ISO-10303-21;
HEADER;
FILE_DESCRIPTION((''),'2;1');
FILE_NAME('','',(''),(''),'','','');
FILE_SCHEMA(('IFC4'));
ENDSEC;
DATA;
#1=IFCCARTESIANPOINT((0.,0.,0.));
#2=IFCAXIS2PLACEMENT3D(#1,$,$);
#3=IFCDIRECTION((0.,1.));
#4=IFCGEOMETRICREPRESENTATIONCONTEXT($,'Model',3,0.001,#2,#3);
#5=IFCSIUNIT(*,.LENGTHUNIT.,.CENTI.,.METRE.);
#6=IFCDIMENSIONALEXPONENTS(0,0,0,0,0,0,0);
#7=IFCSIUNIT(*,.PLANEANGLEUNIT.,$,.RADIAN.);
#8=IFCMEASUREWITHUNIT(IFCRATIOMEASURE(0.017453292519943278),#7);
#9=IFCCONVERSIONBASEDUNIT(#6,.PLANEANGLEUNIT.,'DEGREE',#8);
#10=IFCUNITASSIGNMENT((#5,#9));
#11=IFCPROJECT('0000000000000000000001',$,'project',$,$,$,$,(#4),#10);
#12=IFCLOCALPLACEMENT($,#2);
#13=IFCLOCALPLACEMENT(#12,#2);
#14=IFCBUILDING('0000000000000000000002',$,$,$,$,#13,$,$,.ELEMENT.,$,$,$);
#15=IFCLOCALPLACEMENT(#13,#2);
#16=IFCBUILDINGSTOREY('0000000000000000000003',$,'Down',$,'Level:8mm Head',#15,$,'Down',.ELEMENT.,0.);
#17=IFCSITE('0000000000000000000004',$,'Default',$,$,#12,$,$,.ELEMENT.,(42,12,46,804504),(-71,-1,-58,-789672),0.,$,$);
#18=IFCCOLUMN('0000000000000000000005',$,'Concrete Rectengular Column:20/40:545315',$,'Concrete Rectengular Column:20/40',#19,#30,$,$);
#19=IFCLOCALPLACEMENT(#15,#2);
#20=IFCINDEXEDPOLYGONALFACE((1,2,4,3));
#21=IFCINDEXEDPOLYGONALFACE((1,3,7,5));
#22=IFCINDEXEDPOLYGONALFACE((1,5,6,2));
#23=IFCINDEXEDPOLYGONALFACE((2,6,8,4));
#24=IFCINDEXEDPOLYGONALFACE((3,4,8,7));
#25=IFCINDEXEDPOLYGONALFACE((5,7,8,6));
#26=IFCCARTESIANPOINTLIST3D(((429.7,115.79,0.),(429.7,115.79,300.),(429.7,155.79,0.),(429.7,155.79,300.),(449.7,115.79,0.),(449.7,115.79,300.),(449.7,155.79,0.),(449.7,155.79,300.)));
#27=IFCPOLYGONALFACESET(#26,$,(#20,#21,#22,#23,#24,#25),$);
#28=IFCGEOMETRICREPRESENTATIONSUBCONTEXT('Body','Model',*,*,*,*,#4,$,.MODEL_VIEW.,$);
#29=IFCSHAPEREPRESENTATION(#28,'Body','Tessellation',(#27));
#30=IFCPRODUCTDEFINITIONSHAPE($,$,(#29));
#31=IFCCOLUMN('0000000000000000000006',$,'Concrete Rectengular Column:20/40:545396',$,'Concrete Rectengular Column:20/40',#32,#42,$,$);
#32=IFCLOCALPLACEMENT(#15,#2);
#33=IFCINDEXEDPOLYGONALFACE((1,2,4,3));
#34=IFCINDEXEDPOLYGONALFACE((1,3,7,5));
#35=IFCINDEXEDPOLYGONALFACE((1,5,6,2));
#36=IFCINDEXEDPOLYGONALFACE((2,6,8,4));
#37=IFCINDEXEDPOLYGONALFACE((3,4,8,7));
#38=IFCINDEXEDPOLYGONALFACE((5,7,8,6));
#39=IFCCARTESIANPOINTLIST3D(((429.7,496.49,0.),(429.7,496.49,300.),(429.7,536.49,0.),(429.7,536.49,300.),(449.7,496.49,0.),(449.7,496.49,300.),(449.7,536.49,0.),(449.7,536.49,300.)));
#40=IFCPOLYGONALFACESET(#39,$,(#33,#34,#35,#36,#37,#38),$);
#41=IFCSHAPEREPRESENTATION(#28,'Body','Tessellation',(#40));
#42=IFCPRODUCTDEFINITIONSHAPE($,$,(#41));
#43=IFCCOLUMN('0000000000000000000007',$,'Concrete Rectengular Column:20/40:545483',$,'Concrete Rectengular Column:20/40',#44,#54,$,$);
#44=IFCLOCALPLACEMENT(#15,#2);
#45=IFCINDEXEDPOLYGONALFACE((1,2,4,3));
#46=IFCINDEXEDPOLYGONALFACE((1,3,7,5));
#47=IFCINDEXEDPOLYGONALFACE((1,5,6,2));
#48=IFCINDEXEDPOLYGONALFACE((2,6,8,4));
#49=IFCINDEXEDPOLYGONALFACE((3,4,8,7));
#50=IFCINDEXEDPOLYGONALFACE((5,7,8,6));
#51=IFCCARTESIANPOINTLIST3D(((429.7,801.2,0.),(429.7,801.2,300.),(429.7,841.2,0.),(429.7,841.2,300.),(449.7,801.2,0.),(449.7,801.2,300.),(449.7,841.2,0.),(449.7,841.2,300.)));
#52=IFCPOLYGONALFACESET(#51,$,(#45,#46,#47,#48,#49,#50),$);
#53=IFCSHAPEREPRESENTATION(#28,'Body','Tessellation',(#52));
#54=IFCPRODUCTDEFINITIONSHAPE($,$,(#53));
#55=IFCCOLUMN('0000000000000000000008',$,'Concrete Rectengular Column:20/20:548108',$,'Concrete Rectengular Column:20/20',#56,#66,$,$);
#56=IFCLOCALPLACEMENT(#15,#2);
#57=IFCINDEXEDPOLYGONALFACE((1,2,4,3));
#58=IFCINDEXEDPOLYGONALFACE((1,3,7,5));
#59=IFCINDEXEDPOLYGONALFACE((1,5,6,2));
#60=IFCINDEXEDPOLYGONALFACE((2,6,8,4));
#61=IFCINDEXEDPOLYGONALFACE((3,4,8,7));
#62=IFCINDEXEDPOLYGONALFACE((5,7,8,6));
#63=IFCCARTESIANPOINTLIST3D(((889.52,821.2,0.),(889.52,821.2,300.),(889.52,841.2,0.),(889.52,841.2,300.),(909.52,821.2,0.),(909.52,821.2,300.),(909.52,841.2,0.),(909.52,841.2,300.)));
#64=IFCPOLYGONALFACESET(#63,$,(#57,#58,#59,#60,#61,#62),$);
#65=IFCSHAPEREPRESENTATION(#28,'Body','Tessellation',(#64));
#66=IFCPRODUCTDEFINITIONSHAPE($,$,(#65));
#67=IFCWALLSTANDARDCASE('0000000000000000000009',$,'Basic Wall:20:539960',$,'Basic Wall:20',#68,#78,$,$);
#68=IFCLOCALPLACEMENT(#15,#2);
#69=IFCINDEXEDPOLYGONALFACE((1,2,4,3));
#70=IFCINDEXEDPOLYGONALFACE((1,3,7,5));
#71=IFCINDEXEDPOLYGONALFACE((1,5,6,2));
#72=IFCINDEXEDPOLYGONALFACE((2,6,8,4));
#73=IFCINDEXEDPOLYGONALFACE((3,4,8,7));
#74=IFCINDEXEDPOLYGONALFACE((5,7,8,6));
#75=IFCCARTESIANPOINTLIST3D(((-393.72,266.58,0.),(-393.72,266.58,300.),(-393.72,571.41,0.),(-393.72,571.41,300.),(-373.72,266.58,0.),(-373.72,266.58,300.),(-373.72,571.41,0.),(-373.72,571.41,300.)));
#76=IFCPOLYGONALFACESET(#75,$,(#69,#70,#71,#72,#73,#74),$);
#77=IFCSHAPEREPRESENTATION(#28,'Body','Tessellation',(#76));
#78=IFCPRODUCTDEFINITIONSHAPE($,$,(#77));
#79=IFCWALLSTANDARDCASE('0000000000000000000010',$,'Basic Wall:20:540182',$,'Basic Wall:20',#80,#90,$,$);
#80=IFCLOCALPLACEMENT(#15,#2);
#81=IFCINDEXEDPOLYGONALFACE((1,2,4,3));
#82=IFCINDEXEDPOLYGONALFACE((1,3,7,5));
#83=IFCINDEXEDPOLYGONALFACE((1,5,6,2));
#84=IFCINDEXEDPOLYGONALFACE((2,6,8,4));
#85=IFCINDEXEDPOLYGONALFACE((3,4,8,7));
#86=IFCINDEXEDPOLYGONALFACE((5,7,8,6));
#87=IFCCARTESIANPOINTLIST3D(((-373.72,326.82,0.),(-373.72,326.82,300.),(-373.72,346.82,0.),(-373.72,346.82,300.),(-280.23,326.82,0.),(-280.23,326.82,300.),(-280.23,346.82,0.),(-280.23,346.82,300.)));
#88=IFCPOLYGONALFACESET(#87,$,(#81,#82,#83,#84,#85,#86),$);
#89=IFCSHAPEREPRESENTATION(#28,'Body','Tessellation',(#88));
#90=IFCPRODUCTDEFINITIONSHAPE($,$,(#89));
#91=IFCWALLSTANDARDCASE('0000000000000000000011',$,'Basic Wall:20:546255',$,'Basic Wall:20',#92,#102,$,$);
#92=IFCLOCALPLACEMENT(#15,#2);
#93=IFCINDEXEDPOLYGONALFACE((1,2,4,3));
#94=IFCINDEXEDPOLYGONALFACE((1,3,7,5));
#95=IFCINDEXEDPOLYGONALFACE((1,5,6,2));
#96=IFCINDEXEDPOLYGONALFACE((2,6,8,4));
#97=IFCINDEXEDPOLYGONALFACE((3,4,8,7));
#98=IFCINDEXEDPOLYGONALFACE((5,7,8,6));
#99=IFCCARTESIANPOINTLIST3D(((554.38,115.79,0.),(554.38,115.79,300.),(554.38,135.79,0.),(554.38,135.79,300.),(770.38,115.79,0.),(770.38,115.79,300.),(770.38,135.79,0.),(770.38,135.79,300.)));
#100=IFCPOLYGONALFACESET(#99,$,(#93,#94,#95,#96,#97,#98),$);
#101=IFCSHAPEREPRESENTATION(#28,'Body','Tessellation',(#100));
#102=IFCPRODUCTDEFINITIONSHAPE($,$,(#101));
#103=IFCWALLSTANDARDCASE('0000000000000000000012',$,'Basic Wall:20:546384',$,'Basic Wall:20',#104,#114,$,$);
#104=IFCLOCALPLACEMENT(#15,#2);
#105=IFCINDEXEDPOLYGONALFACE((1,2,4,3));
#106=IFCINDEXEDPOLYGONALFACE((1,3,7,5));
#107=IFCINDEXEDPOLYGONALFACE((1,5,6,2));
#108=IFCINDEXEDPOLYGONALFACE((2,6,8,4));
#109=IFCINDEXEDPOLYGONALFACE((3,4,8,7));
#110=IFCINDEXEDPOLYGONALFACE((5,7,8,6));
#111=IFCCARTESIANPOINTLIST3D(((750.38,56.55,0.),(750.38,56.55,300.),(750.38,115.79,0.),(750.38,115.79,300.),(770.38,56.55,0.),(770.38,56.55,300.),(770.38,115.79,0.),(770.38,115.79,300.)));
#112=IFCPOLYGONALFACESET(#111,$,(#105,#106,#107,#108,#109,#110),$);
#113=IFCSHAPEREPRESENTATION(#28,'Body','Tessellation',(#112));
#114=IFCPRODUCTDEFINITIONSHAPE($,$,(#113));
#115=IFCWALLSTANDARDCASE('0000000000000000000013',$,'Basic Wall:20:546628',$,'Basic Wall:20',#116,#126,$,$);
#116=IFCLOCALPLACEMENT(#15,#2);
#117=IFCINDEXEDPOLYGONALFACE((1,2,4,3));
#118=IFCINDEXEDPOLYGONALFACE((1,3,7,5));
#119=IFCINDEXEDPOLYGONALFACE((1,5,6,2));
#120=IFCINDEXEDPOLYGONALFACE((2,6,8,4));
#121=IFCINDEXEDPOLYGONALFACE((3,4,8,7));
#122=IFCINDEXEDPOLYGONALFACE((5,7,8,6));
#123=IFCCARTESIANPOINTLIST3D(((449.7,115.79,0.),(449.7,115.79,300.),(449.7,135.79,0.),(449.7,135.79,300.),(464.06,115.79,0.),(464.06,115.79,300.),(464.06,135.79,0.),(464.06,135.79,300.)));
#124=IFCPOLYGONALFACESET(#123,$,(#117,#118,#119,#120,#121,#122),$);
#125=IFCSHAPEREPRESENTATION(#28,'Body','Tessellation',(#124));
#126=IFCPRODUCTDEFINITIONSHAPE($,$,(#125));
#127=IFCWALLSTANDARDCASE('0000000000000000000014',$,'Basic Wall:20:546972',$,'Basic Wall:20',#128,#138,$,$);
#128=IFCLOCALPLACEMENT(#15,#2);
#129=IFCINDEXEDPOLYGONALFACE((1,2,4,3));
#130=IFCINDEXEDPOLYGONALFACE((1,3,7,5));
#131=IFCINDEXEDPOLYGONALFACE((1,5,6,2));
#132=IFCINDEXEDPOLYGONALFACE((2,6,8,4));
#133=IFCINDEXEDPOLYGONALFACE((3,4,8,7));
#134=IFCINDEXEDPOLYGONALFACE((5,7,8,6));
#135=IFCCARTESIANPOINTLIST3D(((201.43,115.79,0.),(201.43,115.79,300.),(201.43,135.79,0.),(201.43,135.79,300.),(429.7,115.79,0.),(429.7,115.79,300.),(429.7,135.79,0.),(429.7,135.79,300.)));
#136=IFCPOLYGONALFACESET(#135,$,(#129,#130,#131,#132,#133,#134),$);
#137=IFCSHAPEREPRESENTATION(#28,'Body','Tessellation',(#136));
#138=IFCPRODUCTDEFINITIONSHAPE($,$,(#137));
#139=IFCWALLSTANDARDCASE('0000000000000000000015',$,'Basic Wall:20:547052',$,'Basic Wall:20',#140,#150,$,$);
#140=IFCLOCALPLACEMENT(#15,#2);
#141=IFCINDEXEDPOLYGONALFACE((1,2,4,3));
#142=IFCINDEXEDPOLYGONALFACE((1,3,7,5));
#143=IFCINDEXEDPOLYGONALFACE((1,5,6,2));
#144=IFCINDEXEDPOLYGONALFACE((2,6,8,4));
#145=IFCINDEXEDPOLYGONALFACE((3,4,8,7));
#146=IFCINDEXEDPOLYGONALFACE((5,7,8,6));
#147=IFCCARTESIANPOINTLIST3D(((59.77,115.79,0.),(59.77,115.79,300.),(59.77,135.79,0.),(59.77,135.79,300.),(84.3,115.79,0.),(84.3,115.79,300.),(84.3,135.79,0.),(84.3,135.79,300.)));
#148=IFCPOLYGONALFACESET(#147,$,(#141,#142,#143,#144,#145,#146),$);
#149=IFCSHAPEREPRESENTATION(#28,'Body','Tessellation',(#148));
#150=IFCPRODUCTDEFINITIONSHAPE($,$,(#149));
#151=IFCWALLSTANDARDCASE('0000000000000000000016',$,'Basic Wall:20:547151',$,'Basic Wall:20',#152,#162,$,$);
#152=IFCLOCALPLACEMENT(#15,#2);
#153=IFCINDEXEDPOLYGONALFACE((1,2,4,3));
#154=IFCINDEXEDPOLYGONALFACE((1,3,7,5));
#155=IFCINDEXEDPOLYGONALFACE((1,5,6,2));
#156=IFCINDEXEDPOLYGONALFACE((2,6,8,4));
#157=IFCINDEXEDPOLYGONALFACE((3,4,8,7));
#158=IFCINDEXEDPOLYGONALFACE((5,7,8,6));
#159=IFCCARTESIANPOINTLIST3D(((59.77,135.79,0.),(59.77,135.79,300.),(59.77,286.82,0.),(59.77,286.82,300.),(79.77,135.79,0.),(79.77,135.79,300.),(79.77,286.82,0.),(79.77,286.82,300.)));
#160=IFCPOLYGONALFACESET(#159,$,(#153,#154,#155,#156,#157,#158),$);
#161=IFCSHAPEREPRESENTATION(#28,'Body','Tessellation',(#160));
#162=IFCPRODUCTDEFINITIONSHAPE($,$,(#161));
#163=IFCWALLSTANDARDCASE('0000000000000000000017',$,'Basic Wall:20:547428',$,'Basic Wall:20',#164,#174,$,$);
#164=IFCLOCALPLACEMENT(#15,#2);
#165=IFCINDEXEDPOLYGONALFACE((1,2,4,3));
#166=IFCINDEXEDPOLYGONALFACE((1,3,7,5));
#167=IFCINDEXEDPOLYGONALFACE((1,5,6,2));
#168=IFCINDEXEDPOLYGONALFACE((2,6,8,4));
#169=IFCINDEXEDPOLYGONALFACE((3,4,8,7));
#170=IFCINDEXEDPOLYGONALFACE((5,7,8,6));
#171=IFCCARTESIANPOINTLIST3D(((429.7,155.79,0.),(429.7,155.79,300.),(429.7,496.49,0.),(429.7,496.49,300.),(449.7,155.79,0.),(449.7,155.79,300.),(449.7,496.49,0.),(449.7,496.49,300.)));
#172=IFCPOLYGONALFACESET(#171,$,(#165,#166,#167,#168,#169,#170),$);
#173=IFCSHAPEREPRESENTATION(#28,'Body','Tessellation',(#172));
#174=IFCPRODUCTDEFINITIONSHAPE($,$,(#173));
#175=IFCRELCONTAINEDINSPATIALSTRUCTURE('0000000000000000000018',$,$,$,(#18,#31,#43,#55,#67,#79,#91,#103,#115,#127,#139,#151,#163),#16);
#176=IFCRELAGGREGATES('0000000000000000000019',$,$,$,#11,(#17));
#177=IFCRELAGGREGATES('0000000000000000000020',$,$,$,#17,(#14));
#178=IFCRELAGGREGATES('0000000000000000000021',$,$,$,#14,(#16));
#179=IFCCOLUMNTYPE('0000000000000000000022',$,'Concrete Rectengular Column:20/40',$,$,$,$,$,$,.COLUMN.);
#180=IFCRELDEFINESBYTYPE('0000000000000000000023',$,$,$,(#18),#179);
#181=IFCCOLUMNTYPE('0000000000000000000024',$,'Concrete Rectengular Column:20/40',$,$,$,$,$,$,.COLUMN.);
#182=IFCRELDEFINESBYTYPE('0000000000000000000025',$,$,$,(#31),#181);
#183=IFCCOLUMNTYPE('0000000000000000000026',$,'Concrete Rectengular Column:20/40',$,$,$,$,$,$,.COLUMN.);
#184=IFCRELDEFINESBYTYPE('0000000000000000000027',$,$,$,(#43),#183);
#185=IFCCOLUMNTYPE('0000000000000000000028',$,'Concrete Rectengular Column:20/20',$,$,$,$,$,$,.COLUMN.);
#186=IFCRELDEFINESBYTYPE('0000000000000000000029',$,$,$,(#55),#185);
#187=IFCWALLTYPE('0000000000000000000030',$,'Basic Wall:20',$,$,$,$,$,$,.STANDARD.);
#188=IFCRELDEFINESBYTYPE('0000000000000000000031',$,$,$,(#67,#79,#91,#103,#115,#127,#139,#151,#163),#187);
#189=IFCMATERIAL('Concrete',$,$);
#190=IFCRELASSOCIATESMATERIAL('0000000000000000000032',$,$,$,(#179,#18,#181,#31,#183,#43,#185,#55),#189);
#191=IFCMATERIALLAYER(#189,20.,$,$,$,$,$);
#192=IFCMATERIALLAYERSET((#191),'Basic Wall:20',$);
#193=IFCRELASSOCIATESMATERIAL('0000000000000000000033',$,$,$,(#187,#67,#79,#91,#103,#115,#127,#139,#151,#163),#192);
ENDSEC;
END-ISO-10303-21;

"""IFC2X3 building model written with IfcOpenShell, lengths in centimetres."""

from ifc_helpers import new_model, entity, si_unit, converted_unit, direction, frame, frame_2d, origin, origin_2d_with_axis, place, context, subcontext, project, spatial, polyline, rectangle, extrude, clip, bounded_halfspace, source, transform, mapped, material, layer, layer_set, layer_usage, type_object, type_shapes, element, save


model = new_model("IFC2X3")

# Units and contexts
model_context = context("Model", 3, precision=0.001, world=origin(), true_north=direction((0.0, 1.0)))
body_context = subcontext(model_context, "Body", "Model", "MODEL_VIEW")
ifc_project = project(units=[si_unit("LENGTHUNIT", "METRE", prefix="CENTI"), converted_unit("PLANEANGLEUNIT", "DEGREE", entity("IfcRatioMeasure", 0.017453292519943278), si_unit("PLANEANGLEUNIT", "RADIAN"), dimensions=[0, 0, 0, 0, 0, 0, 0])], contexts=[model_context])

# Site, building, storey
site_placement = place(None, origin())
site = spatial("IfcSite", under=ifc_project, at=site_placement, Name="Default", CompositionType="ELEMENT", RefLatitude=(42, 12, 46, 804504), RefLongitude=(-71, -1, -58, -789672), RefElevation=0.0)
building_placement = place(site_placement, origin())
building = spatial("IfcBuilding", under=site, at=building_placement, CompositionType="ELEMENT")
storey_placement = place(building_placement, origin())
storey = spatial("IfcBuildingStorey", under=building, at=storey_placement, Name="Down", ObjectType="Level:8mm Head", LongName="Down", CompositionType="ELEMENT", Elevation=0.0)

# Columns
ifc_material = material(Name="Concrete")
column_type_1 = type_object("IfcColumnType", Name="Concrete Rectengular Column:20/40", PredefinedType="COLUMN", material=ifc_material)
shared_shape_1 = source(origin(), body_context, "Body", "SweptSolid", [
    extrude(rectangle(XDim=40.0, YDim=20.0, at=origin_2d_with_axis()), frame((439.7, 135.79, 0.0), z_axis=(0.0, 0.0, 1.0), x_axis=(0.0, -1.0, 0.0)), (0.0, 0.0, 1.0), 300.0),
])
type_shapes(column_type_1, [shared_shape_1])
column_1_placement = place(storey_placement, origin())
element("IfcColumn", 1, at=column_1_placement, inside=storey, type_object=column_type_1, material=ifc_material, Name="Concrete Rectengular Column:20/40:545315", ObjectType="Concrete Rectengular Column:20/40", context=body_context, shape_type="MappedRepresentation", body=[
    mapped(shared_shape_1, transform((0.0, 0.0, 0.0), scale=1.0)),
])
column_type_2 = type_object("IfcColumnType", Name="Concrete Rectengular Column:20/40", PredefinedType="COLUMN", material=ifc_material)
shared_shape_2 = source(origin(), body_context, "Body", "SweptSolid", [
    extrude(rectangle(XDim=40.0, YDim=20.0, at=origin_2d_with_axis()), frame((439.7, 516.49, 0.0), z_axis=(0.0, 0.0, 1.0), x_axis=(0.0, -1.0, 0.0)), (0.0, 0.0, 1.0), 300.0),
])
type_shapes(column_type_2, [shared_shape_2])
column_2_placement = place(storey_placement, origin())
element("IfcColumn", 2, at=column_2_placement, inside=storey, type_object=column_type_2, material=ifc_material, Name="Concrete Rectengular Column:20/40:545396", ObjectType="Concrete Rectengular Column:20/40", context=body_context, shape_type="MappedRepresentation", body=[
    mapped(shared_shape_2, transform((0.0, 0.0, 0.0), scale=1.0)),
])
column_type_3 = type_object("IfcColumnType", Name="Concrete Rectengular Column:20/40", PredefinedType="COLUMN", material=ifc_material)
shared_shape_3 = source(origin(), body_context, "Body", "SweptSolid", [
    extrude(rectangle(XDim=40.0, YDim=20.0, at=origin_2d_with_axis()), frame((439.7, 821.2, 0.0), z_axis=(0.0, 0.0, 1.0), x_axis=(0.0, -1.0, 0.0)), (0.0, 0.0, 1.0), 300.0),
])
type_shapes(column_type_3, [shared_shape_3])
column_3_placement = place(storey_placement, origin())
element("IfcColumn", 3, at=column_3_placement, inside=storey, type_object=column_type_3, material=ifc_material, Name="Concrete Rectengular Column:20/40:545483", ObjectType="Concrete Rectengular Column:20/40", context=body_context, shape_type="MappedRepresentation", body=[
    mapped(shared_shape_3, transform((0.0, 0.0, 0.0), scale=1.0)),
])
column_type_4 = type_object("IfcColumnType", Name="Concrete Rectengular Column:20/20", PredefinedType="COLUMN", material=ifc_material)
shared_shape_4 = source(origin(), body_context, "Body", "SweptSolid", [
    extrude(rectangle(XDim=20.0, YDim=20.0, at=frame_2d((0.0, 0.0), x_axis=(1.0, 0.0))), frame((899.52, 831.2, 0.0), z_axis=(0.0, 0.0, 1.0), x_axis=(0.0, -1.0, 0.0)), (0.0, 0.0, 1.0), 300.0),
])
type_shapes(column_type_4, [shared_shape_4])
column_4_placement = place(storey_placement, origin())
element("IfcColumn", 4, at=column_4_placement, inside=storey, type_object=column_type_4, material=ifc_material, Name="Concrete Rectengular Column:20/20:548108", ObjectType="Concrete Rectengular Column:20/20", context=body_context, shape_type="MappedRepresentation", body=[
    mapped(shared_shape_4, transform((0.0, 0.0, 0.0), scale=1.0)),
])

# Walls
ifc_layer_1 = layer(ifc_material, 20.0)
ifc_layer_set_1 = layer_set([ifc_layer_1], Name="Basic Wall:20")
ifc_layer_usage_1 = layer_usage(ifc_layer_set_1, "AXIS2", "POSITIVE", -10.0)
wall_type_1 = type_object("IfcWallType", Name="Basic Wall:20", PredefinedType="STANDARD", material=ifc_layer_set_1)
wall_1_placement = place(storey_placement, frame((-383.72, 571.41, 0.0), z_axis=(0.0, 0.0, 1.0), x_axis=(0.0, -1.0, 0.0)))
element("IfcWallStandardCase", 5, at=wall_1_placement, inside=storey, type_object=wall_type_1, material=ifc_layer_usage_1, Name="Basic Wall:20:539960", ObjectType="Basic Wall:20", context=body_context, shape_type="SweptSolid", body=[
    extrude(rectangle(XDim=304.83, YDim=20.0, at=frame_2d((152.41, 0.0), x_axis=(-1.0, 0.0))), origin(), (0.0, 0.0, 1.0), 300.0),
])
ifc_layer_usage_2 = layer_usage(ifc_layer_set_1, "AXIS2", "NEGATIVE", 10.0)
wall_2_placement = place(storey_placement, frame((-373.72, 336.82, 0.0)))
element("IfcWallStandardCase", 6, at=wall_2_placement, inside=storey, type_object=wall_type_1, material=ifc_layer_usage_2, Name="Basic Wall:20:540182", ObjectType="Basic Wall:20", context=body_context, shape_type="SweptSolid", body=[
    extrude(rectangle(XDim=93.49, YDim=20.0, at=frame_2d((46.75, 0.0), x_axis=(-1.0, 0.0))), origin(), (0.0, 0.0, 1.0), 300.0),
])
ifc_layer_usage_3 = layer_usage(ifc_layer_set_1, "AXIS2", "POSITIVE", -10.0)
wall_3_placement = place(storey_placement, frame((554.38, 125.79, 0.0)))
element("IfcWallStandardCase", 7, at=wall_3_placement, inside=storey, type_object=wall_type_1, material=ifc_layer_usage_3, Name="Basic Wall:20:546255", ObjectType="Basic Wall:20", context=body_context, shape_type="SweptSolid", body=[
    extrude(rectangle(XDim=216.0, YDim=20.0, at=frame_2d((108.0, 0.0), x_axis=(-1.0, 0.0))), origin(), (0.0, 0.0, 1.0), 300.0),
])
ifc_layer_usage_4 = layer_usage(ifc_layer_set_1, "AXIS2", "NEGATIVE", 10.0)
wall_4_placement = place(storey_placement, frame((760.38, 115.79, 0.0), z_axis=(0.0, 0.0, 1.0), x_axis=(0.0, -1.0, 0.0)))
element("IfcWallStandardCase", 8, at=wall_4_placement, inside=storey, type_object=wall_type_1, material=ifc_layer_usage_4, Name="Basic Wall:20:546384", ObjectType="Basic Wall:20", context=body_context, shape_type="SweptSolid", body=[
    extrude(rectangle(XDim=59.24, YDim=20.0, at=frame_2d((29.62, 0.0), x_axis=(-1.0, 0.0))), origin(), (0.0, 0.0, 1.0), 300.0),
])
ifc_layer_usage_5 = layer_usage(ifc_layer_set_1, "AXIS2", "POSITIVE", -10.0)
wall_5_placement = place(storey_placement, frame((464.06, 125.79, 0.0), z_axis=(0.0, 0.0, 1.0), x_axis=(-1.0, 0.0, 0.0)))
element("IfcWallStandardCase", 9, at=wall_5_placement, inside=storey, type_object=wall_type_1, material=ifc_layer_usage_5, Name="Basic Wall:20:546628", ObjectType="Basic Wall:20", context=body_context, shape_type="Clipping", body=[
    clip(extrude(rectangle(XDim=14.35, YDim=20.0, at=frame_2d((7.18, 0.0), x_axis=(-1.0, 0.0))), origin(), (0.0, 0.0, 1.0), 300.0), bounded_halfspace(frame((14.35, -10.0, 300.0), z_axis=(-1.0, 0.0, 0.0), x_axis=(0.0, 0.0, -1.0)), True, frame((14.35, -10.0, 300.0), z_axis=(-1.0, 0.0, 0.0), x_axis=(0.0, 0.0, -1.0)), polyline([(0.0, 0.0), (0.0, -20.0), (300.0, -20.0), (300.0, 0.0), (22.0, 0.0), (0.0, 0.0)]))),
])
ifc_layer_usage_6 = layer_usage(ifc_layer_set_1, "AXIS2", "NEGATIVE", 10.0)
wall_6_placement = place(storey_placement, frame((429.7, 125.79, 0.0), z_axis=(0.0, 0.0, 1.0), x_axis=(-1.0, 0.0, 0.0)))
element("IfcWallStandardCase", 10, at=wall_6_placement, inside=storey, type_object=wall_type_1, material=ifc_layer_usage_6, Name="Basic Wall:20:546972", ObjectType="Basic Wall:20", context=body_context, shape_type="SweptSolid", body=[
    extrude(rectangle(XDim=228.27, YDim=20.0, at=frame_2d((114.14, 0.0), x_axis=(-1.0, 0.0))), origin(), (0.0, 0.0, 1.0), 300.0),
])
ifc_layer_usage_7 = layer_usage(ifc_layer_set_1, "AXIS2", "NEGATIVE", 10.0)
wall_7_placement = place(storey_placement, frame((84.3, 125.79, 0.0), z_axis=(0.0, 0.0, 1.0), x_axis=(-1.0, 0.0, 0.0)))
element("IfcWallStandardCase", 11, at=wall_7_placement, inside=storey, type_object=wall_type_1, material=ifc_layer_usage_7, Name="Basic Wall:20:547052", ObjectType="Basic Wall:20", context=body_context, shape_type="SweptSolid", body=[
    extrude(rectangle(XDim=24.53, YDim=20.0, at=frame_2d((12.27, 0.0), x_axis=(-1.0, 0.0))), origin(), (0.0, 0.0, 1.0), 300.0),
])
ifc_layer_usage_8 = layer_usage(ifc_layer_set_1, "AXIS2", "NEGATIVE", 10.0)
wall_8_placement = place(storey_placement, frame((69.77, 135.79, 0.0), z_axis=(0.0, 0.0, 1.0), x_axis=(0.0, 1.0, 0.0)))
element("IfcWallStandardCase", 12, at=wall_8_placement, inside=storey, type_object=wall_type_1, material=ifc_layer_usage_8, Name="Basic Wall:20:547151", ObjectType="Basic Wall:20", context=body_context, shape_type="SweptSolid", body=[
    extrude(rectangle(XDim=151.03, YDim=20.0, at=frame_2d((75.52, 0.0), x_axis=(-1.0, 0.0))), origin(), (0.0, 0.0, 1.0), 300.0),
])
ifc_layer_usage_9 = layer_usage(ifc_layer_set_1, "AXIS2", "POSITIVE", -10.0)
wall_9_placement = place(storey_placement, frame((439.7, 155.79, 0.0), z_axis=(0.0, 0.0, 1.0), x_axis=(0.0, 1.0, 0.0)))
element("IfcWallStandardCase", 13, at=wall_9_placement, inside=storey, type_object=wall_type_1, material=ifc_layer_usage_9, Name="Basic Wall:20:547428", ObjectType="Basic Wall:20", context=body_context, shape_type="SweptSolid", body=[
    extrude(rectangle(XDim=340.7, YDim=20.0, at=frame_2d((170.35, 0.0), x_axis=(-1.0, 0.0))), origin(), (0.0, 0.0, 1.0), 300.0),
])

save(model, "model.ifc")
